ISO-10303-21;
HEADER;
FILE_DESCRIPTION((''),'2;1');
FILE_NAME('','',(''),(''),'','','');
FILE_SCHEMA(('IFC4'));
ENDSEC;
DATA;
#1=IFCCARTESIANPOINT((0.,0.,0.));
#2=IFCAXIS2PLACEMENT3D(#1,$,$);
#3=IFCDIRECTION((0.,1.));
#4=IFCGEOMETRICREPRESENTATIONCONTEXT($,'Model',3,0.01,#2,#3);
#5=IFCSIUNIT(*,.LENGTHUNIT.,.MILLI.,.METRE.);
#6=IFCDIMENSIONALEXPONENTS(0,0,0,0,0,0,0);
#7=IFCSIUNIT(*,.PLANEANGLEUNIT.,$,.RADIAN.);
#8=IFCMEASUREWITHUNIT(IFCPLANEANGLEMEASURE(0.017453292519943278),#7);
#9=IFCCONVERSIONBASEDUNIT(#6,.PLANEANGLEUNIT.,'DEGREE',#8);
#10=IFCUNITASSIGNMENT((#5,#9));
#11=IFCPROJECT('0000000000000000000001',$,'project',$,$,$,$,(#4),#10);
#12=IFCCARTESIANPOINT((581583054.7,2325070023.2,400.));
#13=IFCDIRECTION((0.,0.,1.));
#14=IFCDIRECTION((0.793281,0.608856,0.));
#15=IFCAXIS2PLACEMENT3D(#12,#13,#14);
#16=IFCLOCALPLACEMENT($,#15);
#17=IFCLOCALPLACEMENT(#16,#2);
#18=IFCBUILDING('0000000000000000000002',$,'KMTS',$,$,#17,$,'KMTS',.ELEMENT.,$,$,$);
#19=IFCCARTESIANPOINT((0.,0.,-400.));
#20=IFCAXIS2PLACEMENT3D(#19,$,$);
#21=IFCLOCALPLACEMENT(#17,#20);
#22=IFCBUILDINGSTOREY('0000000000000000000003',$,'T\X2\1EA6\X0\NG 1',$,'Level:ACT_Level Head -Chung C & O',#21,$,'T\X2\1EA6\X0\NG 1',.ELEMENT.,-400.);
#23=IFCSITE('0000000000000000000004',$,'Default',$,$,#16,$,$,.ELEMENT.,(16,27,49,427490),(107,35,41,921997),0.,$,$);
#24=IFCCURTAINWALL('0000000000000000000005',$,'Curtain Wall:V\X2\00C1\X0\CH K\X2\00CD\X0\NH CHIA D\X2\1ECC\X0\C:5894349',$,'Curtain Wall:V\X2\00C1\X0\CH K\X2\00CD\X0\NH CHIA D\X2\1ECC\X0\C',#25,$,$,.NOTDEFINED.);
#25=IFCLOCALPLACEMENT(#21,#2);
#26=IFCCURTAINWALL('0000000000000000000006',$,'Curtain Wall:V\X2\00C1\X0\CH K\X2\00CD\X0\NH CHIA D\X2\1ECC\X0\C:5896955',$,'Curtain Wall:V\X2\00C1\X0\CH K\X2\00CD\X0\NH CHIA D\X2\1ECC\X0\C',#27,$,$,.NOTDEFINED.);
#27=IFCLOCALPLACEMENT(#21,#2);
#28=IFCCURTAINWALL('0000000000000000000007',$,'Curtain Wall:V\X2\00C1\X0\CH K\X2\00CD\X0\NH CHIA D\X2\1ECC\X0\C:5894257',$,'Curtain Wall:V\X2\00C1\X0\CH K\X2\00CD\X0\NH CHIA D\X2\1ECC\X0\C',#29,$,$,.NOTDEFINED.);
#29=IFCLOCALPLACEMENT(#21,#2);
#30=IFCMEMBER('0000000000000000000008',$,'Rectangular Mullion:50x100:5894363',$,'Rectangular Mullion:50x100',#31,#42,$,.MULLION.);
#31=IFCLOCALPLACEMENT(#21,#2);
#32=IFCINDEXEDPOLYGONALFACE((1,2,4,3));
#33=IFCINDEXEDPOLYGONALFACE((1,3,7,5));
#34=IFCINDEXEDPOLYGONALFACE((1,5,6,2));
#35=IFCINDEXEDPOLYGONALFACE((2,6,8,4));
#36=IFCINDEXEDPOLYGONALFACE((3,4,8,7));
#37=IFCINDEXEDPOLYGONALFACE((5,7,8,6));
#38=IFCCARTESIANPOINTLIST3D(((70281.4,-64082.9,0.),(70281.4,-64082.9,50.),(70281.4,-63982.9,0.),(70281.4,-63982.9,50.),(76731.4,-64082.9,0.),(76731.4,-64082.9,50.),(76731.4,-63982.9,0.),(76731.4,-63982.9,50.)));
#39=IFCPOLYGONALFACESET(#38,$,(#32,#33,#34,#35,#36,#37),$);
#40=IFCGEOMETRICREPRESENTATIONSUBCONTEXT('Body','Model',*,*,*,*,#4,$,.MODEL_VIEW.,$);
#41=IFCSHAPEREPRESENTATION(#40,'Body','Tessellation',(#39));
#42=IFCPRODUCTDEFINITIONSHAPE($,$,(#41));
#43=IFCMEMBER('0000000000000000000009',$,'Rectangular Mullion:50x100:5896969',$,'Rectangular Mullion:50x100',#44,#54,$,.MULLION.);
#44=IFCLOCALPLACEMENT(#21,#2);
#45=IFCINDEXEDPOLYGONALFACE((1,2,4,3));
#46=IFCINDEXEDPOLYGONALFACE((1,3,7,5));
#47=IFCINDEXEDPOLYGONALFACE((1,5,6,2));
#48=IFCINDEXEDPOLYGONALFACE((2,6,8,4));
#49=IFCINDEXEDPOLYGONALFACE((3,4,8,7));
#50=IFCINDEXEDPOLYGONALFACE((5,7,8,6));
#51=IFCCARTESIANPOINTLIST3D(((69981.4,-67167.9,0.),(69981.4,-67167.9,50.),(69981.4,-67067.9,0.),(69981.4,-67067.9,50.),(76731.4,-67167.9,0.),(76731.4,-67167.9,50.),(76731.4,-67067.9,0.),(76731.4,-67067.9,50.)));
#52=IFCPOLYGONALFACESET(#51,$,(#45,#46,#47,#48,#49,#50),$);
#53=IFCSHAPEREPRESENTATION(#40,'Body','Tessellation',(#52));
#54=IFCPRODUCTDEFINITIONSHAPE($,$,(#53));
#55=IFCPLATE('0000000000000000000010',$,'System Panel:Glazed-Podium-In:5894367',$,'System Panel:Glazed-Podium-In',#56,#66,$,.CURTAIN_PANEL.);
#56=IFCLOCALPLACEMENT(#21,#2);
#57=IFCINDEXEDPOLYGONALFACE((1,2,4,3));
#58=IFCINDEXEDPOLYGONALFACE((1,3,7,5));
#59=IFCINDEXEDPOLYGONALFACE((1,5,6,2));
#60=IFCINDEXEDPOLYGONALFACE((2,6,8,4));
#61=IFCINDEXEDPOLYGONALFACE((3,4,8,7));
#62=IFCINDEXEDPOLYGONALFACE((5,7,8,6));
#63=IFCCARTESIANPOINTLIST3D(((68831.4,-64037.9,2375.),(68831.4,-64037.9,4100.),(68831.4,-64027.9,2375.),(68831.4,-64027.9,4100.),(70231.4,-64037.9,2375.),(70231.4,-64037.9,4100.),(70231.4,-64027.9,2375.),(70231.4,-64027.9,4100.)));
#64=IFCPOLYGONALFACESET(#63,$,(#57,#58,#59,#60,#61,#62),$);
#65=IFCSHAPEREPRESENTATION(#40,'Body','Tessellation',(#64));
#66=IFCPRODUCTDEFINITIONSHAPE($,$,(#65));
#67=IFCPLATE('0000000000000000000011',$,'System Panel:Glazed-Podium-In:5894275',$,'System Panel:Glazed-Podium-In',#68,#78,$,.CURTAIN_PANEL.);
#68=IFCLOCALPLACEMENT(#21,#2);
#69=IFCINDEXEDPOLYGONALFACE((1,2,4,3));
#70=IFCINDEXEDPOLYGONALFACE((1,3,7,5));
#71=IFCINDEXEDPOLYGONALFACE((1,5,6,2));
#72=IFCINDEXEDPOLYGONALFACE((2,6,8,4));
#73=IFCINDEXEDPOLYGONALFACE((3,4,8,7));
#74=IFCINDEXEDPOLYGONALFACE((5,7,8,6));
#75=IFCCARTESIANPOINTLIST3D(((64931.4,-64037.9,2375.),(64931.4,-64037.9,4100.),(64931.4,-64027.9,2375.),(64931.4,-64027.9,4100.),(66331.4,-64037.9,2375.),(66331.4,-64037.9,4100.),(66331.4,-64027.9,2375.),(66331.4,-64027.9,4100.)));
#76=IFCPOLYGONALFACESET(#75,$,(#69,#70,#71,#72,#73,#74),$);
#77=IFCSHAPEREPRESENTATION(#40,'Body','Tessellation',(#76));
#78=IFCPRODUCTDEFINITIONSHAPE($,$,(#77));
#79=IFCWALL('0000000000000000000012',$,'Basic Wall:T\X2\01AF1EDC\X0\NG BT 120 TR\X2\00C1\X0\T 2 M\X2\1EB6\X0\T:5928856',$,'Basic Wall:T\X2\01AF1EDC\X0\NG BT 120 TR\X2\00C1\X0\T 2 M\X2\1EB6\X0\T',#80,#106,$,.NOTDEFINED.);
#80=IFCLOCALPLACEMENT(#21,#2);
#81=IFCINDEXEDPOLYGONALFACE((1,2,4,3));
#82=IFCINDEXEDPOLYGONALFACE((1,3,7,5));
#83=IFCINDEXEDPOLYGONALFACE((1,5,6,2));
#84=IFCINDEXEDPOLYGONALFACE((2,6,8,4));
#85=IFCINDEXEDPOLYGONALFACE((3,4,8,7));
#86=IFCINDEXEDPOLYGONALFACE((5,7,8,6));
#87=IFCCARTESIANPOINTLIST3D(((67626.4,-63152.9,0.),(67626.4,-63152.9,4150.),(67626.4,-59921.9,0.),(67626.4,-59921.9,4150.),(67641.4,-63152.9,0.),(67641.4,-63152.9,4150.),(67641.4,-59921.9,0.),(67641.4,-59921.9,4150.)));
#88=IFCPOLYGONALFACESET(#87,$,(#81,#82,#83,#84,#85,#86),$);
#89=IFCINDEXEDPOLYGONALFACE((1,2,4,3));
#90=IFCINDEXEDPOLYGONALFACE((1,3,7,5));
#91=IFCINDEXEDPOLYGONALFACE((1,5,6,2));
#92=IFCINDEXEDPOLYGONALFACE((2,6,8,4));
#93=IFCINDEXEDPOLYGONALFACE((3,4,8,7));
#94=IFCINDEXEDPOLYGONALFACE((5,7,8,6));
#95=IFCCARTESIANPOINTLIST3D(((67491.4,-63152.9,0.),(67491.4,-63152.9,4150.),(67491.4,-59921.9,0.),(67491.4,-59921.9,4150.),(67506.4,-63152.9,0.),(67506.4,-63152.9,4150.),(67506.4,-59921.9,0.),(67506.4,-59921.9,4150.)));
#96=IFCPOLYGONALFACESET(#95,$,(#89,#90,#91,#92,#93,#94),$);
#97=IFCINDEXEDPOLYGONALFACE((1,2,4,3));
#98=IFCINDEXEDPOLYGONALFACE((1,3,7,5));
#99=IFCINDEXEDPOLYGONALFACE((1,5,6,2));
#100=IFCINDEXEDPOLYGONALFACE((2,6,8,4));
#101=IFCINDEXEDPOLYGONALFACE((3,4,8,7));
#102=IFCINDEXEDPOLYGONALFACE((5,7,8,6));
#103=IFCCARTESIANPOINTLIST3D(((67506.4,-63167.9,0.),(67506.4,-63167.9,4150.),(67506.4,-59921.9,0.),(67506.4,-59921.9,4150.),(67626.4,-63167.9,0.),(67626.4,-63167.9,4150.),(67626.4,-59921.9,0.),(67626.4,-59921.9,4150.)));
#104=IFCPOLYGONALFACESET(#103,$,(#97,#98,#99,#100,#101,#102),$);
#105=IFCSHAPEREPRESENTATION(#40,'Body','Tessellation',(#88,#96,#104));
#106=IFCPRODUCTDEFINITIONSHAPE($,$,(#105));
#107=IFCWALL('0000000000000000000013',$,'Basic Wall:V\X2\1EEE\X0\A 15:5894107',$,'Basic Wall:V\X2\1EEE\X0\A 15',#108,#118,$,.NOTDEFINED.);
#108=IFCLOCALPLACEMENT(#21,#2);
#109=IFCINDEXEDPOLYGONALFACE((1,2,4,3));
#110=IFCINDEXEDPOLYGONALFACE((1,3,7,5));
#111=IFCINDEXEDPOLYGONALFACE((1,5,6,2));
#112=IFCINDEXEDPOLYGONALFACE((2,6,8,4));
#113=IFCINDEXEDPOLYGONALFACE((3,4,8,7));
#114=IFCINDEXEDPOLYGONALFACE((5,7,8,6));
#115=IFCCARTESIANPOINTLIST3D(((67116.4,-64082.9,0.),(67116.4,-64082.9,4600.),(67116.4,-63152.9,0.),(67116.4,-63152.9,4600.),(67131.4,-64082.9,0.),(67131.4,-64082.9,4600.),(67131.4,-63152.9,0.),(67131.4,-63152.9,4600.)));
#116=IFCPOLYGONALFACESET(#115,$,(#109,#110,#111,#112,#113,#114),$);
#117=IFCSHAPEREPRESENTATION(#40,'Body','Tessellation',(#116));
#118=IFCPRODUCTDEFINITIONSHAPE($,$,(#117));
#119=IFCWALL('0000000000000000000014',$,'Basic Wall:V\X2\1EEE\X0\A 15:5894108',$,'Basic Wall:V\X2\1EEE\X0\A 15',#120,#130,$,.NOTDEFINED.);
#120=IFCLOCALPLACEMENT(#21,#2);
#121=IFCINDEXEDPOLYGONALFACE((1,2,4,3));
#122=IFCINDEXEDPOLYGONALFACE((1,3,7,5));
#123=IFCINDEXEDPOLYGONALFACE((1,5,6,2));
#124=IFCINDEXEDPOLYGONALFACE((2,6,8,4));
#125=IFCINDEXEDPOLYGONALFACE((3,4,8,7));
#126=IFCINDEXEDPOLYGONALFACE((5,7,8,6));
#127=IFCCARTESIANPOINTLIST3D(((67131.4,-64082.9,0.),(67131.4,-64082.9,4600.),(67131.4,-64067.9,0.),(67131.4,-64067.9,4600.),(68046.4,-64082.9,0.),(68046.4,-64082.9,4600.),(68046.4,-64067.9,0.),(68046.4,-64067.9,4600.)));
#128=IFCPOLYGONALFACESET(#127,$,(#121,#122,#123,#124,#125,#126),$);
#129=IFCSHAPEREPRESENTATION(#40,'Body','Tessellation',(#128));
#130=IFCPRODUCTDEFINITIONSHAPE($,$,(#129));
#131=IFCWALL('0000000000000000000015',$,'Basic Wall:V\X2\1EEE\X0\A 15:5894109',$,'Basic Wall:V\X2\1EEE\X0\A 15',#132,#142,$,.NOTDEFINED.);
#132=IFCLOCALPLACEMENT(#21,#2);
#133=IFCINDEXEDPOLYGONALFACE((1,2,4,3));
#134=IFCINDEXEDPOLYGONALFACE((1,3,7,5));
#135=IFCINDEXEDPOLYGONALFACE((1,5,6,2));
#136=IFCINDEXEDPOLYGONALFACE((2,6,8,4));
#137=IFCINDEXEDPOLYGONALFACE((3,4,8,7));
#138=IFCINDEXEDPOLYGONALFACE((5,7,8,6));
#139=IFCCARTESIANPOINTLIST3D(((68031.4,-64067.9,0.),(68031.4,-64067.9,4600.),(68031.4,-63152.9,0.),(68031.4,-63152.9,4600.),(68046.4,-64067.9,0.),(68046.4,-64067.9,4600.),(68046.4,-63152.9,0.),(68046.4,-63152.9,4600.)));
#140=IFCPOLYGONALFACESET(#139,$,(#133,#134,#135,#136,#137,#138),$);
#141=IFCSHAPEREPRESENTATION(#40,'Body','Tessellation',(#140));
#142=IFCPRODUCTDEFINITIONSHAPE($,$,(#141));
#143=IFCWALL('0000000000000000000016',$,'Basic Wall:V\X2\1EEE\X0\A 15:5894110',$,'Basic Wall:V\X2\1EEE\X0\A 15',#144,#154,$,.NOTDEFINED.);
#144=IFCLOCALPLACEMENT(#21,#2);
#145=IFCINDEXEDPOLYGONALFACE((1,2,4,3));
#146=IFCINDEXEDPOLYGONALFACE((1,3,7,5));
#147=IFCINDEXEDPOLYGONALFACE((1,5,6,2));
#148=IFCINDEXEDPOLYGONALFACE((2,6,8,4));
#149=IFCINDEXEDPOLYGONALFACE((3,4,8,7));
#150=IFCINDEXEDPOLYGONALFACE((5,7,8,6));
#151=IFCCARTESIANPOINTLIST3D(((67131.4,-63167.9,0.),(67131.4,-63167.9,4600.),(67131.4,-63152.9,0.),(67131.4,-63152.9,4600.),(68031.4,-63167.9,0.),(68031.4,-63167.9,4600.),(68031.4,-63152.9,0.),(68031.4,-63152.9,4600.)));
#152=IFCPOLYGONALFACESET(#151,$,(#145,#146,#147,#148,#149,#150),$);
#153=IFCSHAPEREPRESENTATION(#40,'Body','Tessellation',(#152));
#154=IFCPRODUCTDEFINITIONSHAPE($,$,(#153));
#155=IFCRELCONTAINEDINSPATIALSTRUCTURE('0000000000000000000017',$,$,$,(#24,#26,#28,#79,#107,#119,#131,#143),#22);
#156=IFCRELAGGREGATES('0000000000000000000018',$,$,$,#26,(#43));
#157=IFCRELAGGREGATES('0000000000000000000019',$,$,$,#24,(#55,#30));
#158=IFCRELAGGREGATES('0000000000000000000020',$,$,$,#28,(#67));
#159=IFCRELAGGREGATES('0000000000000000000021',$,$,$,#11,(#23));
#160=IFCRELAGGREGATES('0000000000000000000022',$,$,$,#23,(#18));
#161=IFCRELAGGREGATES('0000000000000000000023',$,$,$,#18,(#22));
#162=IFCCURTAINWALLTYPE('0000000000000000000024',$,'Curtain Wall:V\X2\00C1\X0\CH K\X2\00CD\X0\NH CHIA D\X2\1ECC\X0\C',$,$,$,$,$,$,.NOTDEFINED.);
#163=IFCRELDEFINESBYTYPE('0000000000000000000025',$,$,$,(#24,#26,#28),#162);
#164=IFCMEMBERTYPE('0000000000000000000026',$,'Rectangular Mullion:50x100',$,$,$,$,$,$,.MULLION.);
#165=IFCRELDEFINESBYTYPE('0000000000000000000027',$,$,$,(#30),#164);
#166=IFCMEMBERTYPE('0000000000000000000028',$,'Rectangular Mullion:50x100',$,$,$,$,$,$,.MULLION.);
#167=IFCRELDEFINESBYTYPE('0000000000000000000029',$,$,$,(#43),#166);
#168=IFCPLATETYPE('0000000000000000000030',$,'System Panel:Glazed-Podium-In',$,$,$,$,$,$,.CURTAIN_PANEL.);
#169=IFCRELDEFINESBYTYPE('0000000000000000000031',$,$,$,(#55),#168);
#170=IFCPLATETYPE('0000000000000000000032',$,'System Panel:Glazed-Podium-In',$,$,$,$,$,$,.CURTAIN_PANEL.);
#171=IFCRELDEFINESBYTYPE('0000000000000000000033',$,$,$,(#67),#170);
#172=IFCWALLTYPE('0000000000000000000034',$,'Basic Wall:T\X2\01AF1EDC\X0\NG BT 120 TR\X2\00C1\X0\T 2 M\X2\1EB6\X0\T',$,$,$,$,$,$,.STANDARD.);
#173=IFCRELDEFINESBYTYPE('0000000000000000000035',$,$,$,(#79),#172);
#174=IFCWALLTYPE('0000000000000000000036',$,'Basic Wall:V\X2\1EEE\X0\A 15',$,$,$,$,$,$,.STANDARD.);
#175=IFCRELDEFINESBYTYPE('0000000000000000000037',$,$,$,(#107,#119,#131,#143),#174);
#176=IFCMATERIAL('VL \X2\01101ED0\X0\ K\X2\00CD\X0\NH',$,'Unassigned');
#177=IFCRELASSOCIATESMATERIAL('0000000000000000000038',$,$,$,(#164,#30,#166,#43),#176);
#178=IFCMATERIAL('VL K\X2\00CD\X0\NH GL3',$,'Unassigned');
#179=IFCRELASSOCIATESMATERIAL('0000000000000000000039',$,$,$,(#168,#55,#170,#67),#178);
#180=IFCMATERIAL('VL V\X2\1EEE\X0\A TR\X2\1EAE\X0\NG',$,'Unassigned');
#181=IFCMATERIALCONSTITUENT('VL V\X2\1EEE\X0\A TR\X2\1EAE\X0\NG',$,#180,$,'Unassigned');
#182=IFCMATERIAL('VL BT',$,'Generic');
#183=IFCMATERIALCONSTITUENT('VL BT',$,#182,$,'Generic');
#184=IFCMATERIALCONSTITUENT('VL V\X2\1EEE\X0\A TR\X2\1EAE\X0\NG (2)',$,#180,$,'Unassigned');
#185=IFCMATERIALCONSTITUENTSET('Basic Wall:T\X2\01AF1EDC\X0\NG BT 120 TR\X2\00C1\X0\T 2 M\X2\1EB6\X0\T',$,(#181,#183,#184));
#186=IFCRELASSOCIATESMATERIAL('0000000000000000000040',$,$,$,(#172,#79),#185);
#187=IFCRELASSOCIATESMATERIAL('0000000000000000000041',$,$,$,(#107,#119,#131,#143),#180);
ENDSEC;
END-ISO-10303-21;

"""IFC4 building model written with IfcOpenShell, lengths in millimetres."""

from ifc_helpers import new_model, entity, si_unit, converted_unit, direction, frame, origin, place, context, subcontext, project, spatial, indexed_curve, outline, extrude, source, transform, mapped, material, constituent, constituent_set, type_object, type_shapes, element, aggregate, save


model = new_model("IFC4")

# Units and contexts
model_context = context("Model", 3, precision=0.01, world=origin(), true_north=direction((0.0, 1.0)))
body_context = subcontext(model_context, "Body", "Model", "MODEL_VIEW")
ifc_project = project(units=[si_unit("LENGTHUNIT", "METRE", prefix="MILLI"), converted_unit("PLANEANGLEUNIT", "DEGREE", entity("IfcPlaneAngleMeasure", 0.017453292519943278), si_unit("PLANEANGLEUNIT", "RADIAN"), dimensions=[0, 0, 0, 0, 0, 0, 0])], contexts=[model_context])

# Site, building, storey
site_placement = place(None, frame((581583054.7, 2325070023.2, 400.0), z_axis=(0.0, 0.0, 1.0), x_axis=(0.793281, 0.608856, 0.0)))
site = spatial("IfcSite", under=ifc_project, at=site_placement, Name="Default", CompositionType="ELEMENT", RefLatitude=(16, 27, 49, 427490), RefLongitude=(107, 35, 41, 921997), RefElevation=0.0)
building_placement = place(site_placement, origin())
building = spatial("IfcBuilding", under=site, at=building_placement, Name="KMTS", LongName="KMTS", CompositionType="ELEMENT")
storey_placement = place(building_placement, frame((0.0, 0.0, -400.0)))
storey = spatial("IfcBuildingStorey", under=building, at=storey_placement, Name="TẦNG 1", ObjectType="Level:ACT_Level Head -Chung C & O", LongName="TẦNG 1", CompositionType="ELEMENT", Elevation=-400.0)

# Curtain wall
curtain_wall_type = type_object("IfcCurtainWallType", Name="Curtain Wall:VÁCH KÍNH CHIA DỌC", PredefinedType="NOTDEFINED")
curtain_wall_1_placement = place(storey_placement, frame((0.0, 0.0, 400.0)))
curtain_wall_1 = element("IfcCurtainWall", 1, at=curtain_wall_1_placement, inside=storey, type_object=curtain_wall_type, Name="Curtain Wall:VÁCH KÍNH CHIA DỌC:5894349", ObjectType="Curtain Wall:VÁCH KÍNH CHIA DỌC", PredefinedType="NOTDEFINED")
ifc_material_1 = material(Name="VL ĐỐ KÍNH", Category="Unassigned")

# Curtain wall
curtain_wall_2_placement = place(storey_placement, frame((0.0, 0.0, 400.0)))
curtain_wall_2 = element("IfcCurtainWall", 2, at=curtain_wall_2_placement, inside=storey, type_object=curtain_wall_type, Name="Curtain Wall:VÁCH KÍNH CHIA DỌC:5896955", ObjectType="Curtain Wall:VÁCH KÍNH CHIA DỌC", PredefinedType="NOTDEFINED")

# Curtain wall
curtain_wall_3_placement = place(storey_placement, frame((0.0, 0.0, 400.0)))
curtain_wall_3 = element("IfcCurtainWall", 3, at=curtain_wall_3_placement, inside=storey, type_object=curtain_wall_type, Name="Curtain Wall:VÁCH KÍNH CHIA DỌC:5894257", ObjectType="Curtain Wall:VÁCH KÍNH CHIA DỌC", PredefinedType="NOTDEFINED")

# Members
member_type_1 = type_object("IfcMemberType", Name="Rectangular Mullion:50x100", PredefinedType="MULLION", material=ifc_material_1)
shared_shape_1 = source(origin(), body_context, "Body", "SweptSolid", [
    extrude(outline(indexed_curve([(-25.0, -50.0), (25.0, -50.0), (25.0, 50.0), (-25.0, 50.0), (-25.0, -50.0)], self_intersect=False)), frame((-25.0, 0.0, -6450.0), z_axis=(0.0, 0.0, 1.0), x_axis=(-1.0, 0.0, 0.0)), (0.0, 0.0, 1.0), 6450.0),
])
type_shapes(member_type_1, [shared_shape_1])
member_1_placement = place(curtain_wall_1_placement, frame((70281.4, -64032.9, -400.0), z_axis=(-1.0, 0.0, 0.0), x_axis=(0.0, 0.0, -1.0)))
member_1 = element("IfcMember", 4, at=member_1_placement, type_object=member_type_1, material=ifc_material_1, Name="Rectangular Mullion:50x100:5894363", ObjectType="Rectangular Mullion:50x100", PredefinedType="MULLION", context=body_context, shape_type="MappedRepresentation", body=[
    mapped(shared_shape_1, transform((0.0, 0.0, 0.0), scale=1.0)),
])
member_type_2 = type_object("IfcMemberType", Name="Rectangular Mullion:50x100", PredefinedType="MULLION", material=ifc_material_1)
shared_shape_2 = source(origin(), body_context, "Body", "SweptSolid", [
    extrude(outline(indexed_curve([(-25.0, -50.0), (25.0, -50.0), (25.0, 50.0), (-25.0, 50.0), (-25.0, -50.0)], self_intersect=False)), frame((-25.0, 0.0, -6750.0), z_axis=(0.0, 0.0, 1.0), x_axis=(-1.0, 0.0, 0.0)), (0.0, 0.0, 1.0), 6750.0),
])
type_shapes(member_type_2, [shared_shape_2])
member_2_placement = place(curtain_wall_2_placement, frame((69981.4, -67117.9, -400.0), z_axis=(-1.0, 0.0, 0.0), x_axis=(0.0, 0.0, -1.0)))
member_2 = element("IfcMember", 5, at=member_2_placement, type_object=member_type_2, material=ifc_material_1, Name="Rectangular Mullion:50x100:5896969", ObjectType="Rectangular Mullion:50x100", PredefinedType="MULLION", context=body_context, shape_type="MappedRepresentation", body=[
    mapped(shared_shape_2, transform((0.0, 0.0, 0.0), scale=1.0)),
])

# Plates
ifc_material_2 = material(Name="VL KÍNH GL3", Category="Unassigned")
plate_type_1 = type_object("IfcPlateType", Name="System Panel:Glazed-Podium-In", PredefinedType="CURTAIN_PANEL", material=ifc_material_2)
shared_shape_3 = source(origin(), body_context, "Body", "SweptSolid", [
    extrude(outline(indexed_curve([(-5.0, -700.0), (5.0, -700.0), (5.0, 700.0), (-5.0, 700.0), (-5.0, -700.0)], self_intersect=False)), frame((0.0, 0.0, 0.0), z_axis=(0.0, 0.0, 1.0), x_axis=(0.0, 1.0, 0.0)), (0.0, 0.0, 1.0), 1725.0),
])
type_shapes(plate_type_1, [shared_shape_3])
plate_1_placement = place(curtain_wall_1_placement, frame((69531.4, -64032.9, 1975.0)))
plate_1 = element("IfcPlate", 6, at=plate_1_placement, type_object=plate_type_1, material=ifc_material_2, Name="System Panel:Glazed-Podium-In:5894367", ObjectType="System Panel:Glazed-Podium-In", PredefinedType="CURTAIN_PANEL", context=body_context, shape_type="MappedRepresentation", body=[
    mapped(shared_shape_3, transform((0.0, 0.0, 0.0), scale=1.0)),
])
plate_type_2 = type_object("IfcPlateType", Name="System Panel:Glazed-Podium-In", PredefinedType="CURTAIN_PANEL", material=ifc_material_2)
shared_shape_4 = source(origin(), body_context, "Body", "SweptSolid", [
    extrude(outline(indexed_curve([(-5.0, -700.0), (5.0, -700.0), (5.0, 700.0), (-5.0, 700.0), (-5.0, -700.0)], self_intersect=False)), frame((0.0, 0.0, 0.0), z_axis=(0.0, 0.0, 1.0), x_axis=(0.0, 1.0, 0.0)), (0.0, 0.0, 1.0), 1725.0),
])
type_shapes(plate_type_2, [shared_shape_4])
plate_2_placement = place(curtain_wall_3_placement, frame((65631.4, -64032.9, 1975.0), z_axis=(0.0, 0.0, 1.0), x_axis=(-1.0, 0.0, 0.0)))
plate_2 = element("IfcPlate", 7, at=plate_2_placement, type_object=plate_type_2, material=ifc_material_2, Name="System Panel:Glazed-Podium-In:5894275", ObjectType="System Panel:Glazed-Podium-In", PredefinedType="CURTAIN_PANEL", context=body_context, shape_type="MappedRepresentation", body=[
    mapped(shared_shape_4, transform((0.0, 0.0, 0.0), scale=1.0)),
])
aggregate(curtain_wall_2, [member_2])

# Walls
ifc_material_3 = material(Name="VL VỮA TRẮNG", Category="Unassigned")
ifc_constituent_1 = constituent(ifc_material_3, Name="VL VỮA TRẮNG", Category="Unassigned")
ifc_material_4 = material(Name="VL BT", Category="Generic")
ifc_constituent_2 = constituent(ifc_material_4, Name="VL BT", Category="Generic")
ifc_constituent_3 = constituent(ifc_material_3, Name="VL VỮA TRẮNG (2)", Category="Unassigned")
ifc_constituent_set_1 = constituent_set(constituents=[ifc_constituent_1, ifc_constituent_2, ifc_constituent_3], Name="Basic Wall:TƯỜNG BT 120 TRÁT 2 MẶT")
wall_type_1 = type_object("IfcWallType", Name="Basic Wall:TƯỜNG BT 120 TRÁT 2 MẶT", PredefinedType="STANDARD", material=ifc_constituent_set_1)
wall_1_placement = place(storey_placement, frame((67566.4, -63152.9, 0.0), z_axis=(0.0, 0.0, 1.0), x_axis=(0.0, 1.0, 0.0)))
element("IfcWall", 8, at=wall_1_placement, inside=storey, type_object=wall_type_1, material=ifc_constituent_set_1, Name="Basic Wall:TƯỜNG BT 120 TRÁT 2 MẶT:5928856", ObjectType="Basic Wall:TƯỜNG BT 120 TRÁT 2 MẶT", PredefinedType="NOTDEFINED", context=body_context, shape_type="SweptSolid", body=[
    extrude(outline(indexed_curve([(-7.5, -1615.5), (7.5, -1615.5), (7.5, 1615.5), (-7.5, 1615.5), (-7.5, -1615.5)], self_intersect=False)), frame((1615.5, -67.5, 0.0), z_axis=(0.0, 0.0, 1.0), x_axis=(0.0, 1.0, 0.0)), (0.0, 0.0, 1.0), 4150.0),
    extrude(outline(indexed_curve([(-7.5, -1615.5), (7.5, -1615.5), (7.5, 1615.5), (-7.5, 1615.5), (-7.5, -1615.5)], self_intersect=False)), frame((1615.5, 67.5, 0.0), z_axis=(0.0, 0.0, 1.0), x_axis=(0.0, -1.0, 0.0)), (0.0, 0.0, 1.0), 4150.0),
    extrude(outline(indexed_curve([(-1623.0, -60.0), (1623.0, -60.0), (1623.0, 60.0), (-1623.0, 60.0), (-1623.0, -60.0)], self_intersect=False)), frame((1608.0, 0.0, 0.0)), (0.0, 0.0, 1.0), 4150.0),
])
wall_type_2 = type_object("IfcWallType", Name="Basic Wall:VỮA 15", PredefinedType="STANDARD")
wall_2_placement = place(storey_placement, frame((67123.9, -63152.9, 0.0), z_axis=(0.0, 0.0, 1.0), x_axis=(0.0, -1.0, 0.0)))
element("IfcWall", 9, at=wall_2_placement, inside=storey, type_object=wall_type_2, material=ifc_material_3, Name="Basic Wall:VỮA 15:5894107", ObjectType="Basic Wall:VỮA 15", PredefinedType="NOTDEFINED", context=body_context, shape_type="SweptSolid", body=[
    extrude(outline(indexed_curve([(930.0, 7.5), (0.0, 7.5), (0.0, -7.5), (930.0, -7.5), (930.0, 7.5)], self_intersect=False)), origin(), (0.0, 0.0, 1.0), 4600.0),
])
wall_3_placement = place(storey_placement, frame((67131.4, -64075.4, 0.0)))
element("IfcWall", 10, at=wall_3_placement, inside=storey, type_object=wall_type_2, material=ifc_material_3, Name="Basic Wall:VỮA 15:5894108", ObjectType="Basic Wall:VỮA 15", PredefinedType="NOTDEFINED", context=body_context, shape_type="SweptSolid", body=[
    extrude(outline(indexed_curve([(915.0, 7.5), (0.0, 7.5), (0.0, -7.5), (915.0, -7.5), (915.0, 7.5)], self_intersect=False)), origin(), (0.0, 0.0, 1.0), 4600.0),
])
wall_4_placement = place(storey_placement, frame((68038.9, -64067.9, 0.0), z_axis=(0.0, 0.0, 1.0), x_axis=(0.0, 1.0, 0.0)))
element("IfcWall", 11, at=wall_4_placement, inside=storey, type_object=wall_type_2, material=ifc_material_3, Name="Basic Wall:VỮA 15:5894109", ObjectType="Basic Wall:VỮA 15", PredefinedType="NOTDEFINED", context=body_context, shape_type="SweptSolid", body=[
    extrude(outline(indexed_curve([(915.0, 7.5), (0.0, 7.5), (0.0, -7.5), (915.0, -7.5), (915.0, 7.5)], self_intersect=False)), origin(), (0.0, 0.0, 1.0), 4600.0),
])
wall_5_placement = place(storey_placement, frame((68031.4, -63160.4, 0.0), z_axis=(0.0, 0.0, 1.0), x_axis=(-1.0, 0.0, 0.0)))
element("IfcWall", 12, at=wall_5_placement, inside=storey, type_object=wall_type_2, material=ifc_material_3, Name="Basic Wall:VỮA 15:5894110", ObjectType="Basic Wall:VỮA 15", PredefinedType="NOTDEFINED", context=body_context, shape_type="SweptSolid", body=[
    extrude(outline(indexed_curve([(900.0, 7.5), (0.0, 7.5), (0.0, -7.5), (900.0, -7.5), (900.0, 7.5)], self_intersect=False)), origin(), (0.0, 0.0, 1.0), 4600.0),
])

aggregate(curtain_wall_1, [plate_1, member_1])
aggregate(curtain_wall_3, [plate_2])

save(model, "model.ifc")
